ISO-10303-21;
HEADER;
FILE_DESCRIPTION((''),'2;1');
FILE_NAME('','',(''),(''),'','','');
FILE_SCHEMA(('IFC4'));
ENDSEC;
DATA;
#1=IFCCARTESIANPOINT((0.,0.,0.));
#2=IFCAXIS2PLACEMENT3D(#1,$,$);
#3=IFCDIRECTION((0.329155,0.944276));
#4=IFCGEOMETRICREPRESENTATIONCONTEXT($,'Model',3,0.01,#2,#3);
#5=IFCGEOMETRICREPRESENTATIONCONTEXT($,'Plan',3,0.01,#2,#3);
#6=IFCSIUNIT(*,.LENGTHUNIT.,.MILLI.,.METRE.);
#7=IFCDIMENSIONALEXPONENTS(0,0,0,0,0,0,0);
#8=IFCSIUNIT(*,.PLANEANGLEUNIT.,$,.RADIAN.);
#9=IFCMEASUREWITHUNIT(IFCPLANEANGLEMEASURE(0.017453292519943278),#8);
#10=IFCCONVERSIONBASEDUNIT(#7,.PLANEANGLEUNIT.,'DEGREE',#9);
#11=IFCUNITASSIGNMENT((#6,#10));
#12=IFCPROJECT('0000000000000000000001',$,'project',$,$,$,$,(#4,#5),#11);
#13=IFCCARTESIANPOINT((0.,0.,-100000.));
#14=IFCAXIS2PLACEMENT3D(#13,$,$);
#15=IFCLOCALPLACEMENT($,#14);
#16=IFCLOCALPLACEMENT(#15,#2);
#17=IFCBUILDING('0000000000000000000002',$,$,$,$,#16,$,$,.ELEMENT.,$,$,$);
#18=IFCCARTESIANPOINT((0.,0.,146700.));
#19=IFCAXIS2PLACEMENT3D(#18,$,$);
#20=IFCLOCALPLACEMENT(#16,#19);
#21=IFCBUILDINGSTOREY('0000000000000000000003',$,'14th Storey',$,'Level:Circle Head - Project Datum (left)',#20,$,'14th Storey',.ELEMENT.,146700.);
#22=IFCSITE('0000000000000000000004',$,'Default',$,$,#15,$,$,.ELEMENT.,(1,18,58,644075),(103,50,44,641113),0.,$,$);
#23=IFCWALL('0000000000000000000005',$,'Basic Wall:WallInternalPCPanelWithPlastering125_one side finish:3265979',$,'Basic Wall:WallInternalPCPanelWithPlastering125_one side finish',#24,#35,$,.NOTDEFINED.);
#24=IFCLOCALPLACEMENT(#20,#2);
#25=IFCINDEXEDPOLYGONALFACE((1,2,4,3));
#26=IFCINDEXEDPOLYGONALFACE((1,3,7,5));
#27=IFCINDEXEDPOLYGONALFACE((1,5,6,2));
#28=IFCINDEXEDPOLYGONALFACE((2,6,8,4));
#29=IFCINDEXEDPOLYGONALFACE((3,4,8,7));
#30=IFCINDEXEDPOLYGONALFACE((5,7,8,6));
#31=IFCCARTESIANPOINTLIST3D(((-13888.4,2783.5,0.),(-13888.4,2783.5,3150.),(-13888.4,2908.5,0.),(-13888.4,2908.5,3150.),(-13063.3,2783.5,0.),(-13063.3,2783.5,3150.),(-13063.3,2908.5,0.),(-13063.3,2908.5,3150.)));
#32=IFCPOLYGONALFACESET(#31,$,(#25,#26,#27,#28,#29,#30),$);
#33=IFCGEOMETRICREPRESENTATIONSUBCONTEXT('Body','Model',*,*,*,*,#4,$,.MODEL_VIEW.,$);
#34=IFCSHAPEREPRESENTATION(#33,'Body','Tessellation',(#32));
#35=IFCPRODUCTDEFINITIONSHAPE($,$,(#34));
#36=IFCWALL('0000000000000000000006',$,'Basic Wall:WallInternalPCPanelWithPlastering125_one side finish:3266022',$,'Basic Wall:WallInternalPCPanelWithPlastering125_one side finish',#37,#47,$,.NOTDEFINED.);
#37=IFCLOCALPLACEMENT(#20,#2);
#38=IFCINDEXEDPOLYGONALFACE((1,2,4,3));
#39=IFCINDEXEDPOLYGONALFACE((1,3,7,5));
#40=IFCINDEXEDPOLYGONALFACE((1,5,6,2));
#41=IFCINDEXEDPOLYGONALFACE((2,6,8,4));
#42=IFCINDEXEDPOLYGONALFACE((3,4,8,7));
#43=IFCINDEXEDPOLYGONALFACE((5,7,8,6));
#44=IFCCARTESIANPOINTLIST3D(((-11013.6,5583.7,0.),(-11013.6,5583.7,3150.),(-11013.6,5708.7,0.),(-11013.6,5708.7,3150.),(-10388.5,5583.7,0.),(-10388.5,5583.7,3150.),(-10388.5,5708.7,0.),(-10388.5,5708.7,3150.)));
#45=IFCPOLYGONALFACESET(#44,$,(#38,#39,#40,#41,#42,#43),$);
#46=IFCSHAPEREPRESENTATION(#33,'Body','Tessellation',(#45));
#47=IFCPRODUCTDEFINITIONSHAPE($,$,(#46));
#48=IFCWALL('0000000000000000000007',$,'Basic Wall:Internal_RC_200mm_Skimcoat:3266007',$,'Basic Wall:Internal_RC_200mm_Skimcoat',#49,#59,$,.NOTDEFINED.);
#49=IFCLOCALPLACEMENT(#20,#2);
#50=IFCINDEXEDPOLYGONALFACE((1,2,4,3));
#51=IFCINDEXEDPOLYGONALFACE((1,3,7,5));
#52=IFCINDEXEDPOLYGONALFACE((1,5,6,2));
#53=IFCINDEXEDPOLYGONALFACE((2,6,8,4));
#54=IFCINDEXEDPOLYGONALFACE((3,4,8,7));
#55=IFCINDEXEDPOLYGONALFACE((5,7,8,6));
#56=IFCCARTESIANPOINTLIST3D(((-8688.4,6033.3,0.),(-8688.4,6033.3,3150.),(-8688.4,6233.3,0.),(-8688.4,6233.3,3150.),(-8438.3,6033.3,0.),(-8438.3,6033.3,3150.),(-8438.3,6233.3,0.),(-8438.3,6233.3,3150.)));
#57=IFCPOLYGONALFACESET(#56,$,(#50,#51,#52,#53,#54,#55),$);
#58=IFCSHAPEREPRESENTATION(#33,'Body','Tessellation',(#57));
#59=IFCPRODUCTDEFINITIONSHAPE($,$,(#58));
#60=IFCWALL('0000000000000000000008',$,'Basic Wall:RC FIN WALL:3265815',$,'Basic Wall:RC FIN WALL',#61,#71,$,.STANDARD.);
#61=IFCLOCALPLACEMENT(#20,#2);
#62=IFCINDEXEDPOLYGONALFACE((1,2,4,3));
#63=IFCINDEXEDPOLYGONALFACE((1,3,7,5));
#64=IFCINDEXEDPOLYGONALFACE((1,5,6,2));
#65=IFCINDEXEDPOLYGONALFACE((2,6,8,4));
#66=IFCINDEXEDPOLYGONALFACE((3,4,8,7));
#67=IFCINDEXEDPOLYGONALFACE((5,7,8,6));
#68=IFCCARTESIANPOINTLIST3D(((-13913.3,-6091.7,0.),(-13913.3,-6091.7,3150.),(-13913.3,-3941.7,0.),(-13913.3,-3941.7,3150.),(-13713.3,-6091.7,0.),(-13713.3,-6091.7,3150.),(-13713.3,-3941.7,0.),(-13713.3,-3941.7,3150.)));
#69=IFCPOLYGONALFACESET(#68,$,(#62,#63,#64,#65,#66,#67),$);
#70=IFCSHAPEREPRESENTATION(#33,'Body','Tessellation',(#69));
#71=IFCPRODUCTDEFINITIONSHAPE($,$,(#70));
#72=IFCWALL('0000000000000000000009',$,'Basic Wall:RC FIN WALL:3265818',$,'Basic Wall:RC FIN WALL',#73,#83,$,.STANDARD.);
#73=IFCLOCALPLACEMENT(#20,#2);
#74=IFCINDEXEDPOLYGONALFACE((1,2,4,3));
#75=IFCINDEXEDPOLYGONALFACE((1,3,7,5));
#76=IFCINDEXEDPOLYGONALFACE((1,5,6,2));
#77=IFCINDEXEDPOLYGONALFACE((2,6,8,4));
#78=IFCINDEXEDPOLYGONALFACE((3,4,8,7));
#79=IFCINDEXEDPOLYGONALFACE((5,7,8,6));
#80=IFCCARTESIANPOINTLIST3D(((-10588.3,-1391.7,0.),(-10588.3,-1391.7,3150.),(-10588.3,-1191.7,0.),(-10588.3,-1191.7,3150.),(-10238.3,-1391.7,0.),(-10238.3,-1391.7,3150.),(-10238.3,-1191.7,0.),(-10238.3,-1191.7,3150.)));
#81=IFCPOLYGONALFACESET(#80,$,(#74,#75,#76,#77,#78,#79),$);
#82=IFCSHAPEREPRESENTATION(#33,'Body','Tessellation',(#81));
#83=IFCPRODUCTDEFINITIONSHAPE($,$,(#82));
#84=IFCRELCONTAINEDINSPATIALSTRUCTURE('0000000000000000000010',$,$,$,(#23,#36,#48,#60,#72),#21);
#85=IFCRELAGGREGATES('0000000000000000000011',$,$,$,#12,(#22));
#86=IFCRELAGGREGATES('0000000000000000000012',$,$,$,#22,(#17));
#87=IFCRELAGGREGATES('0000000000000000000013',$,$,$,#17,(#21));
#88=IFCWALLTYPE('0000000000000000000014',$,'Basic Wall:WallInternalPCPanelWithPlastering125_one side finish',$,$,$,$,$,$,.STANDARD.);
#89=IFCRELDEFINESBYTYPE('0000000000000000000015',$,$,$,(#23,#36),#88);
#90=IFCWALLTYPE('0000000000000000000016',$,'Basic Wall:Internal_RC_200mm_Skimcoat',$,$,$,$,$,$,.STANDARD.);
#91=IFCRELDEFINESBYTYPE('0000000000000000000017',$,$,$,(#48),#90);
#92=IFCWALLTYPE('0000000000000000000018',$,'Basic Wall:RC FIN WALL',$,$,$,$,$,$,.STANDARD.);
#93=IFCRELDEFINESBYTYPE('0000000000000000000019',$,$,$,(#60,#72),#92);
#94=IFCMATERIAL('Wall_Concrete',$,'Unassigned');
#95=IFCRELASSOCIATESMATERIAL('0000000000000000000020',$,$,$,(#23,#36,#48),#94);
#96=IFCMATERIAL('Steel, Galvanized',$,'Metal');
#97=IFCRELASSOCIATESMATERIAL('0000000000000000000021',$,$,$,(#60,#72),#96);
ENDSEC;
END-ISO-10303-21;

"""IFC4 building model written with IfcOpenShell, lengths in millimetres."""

from ifc_helpers import new_model, entity, si_unit, converted_unit, direction, frame, origin, place, context, subcontext, project, spatial, indexed_curve, outline, extrude, material, type_object, element, save


model = new_model("IFC4")

# Units and contexts
model_context = context("Model", 3, precision=0.01, world=origin(), true_north=direction((0.329155, 0.944276)))
plan_context = context("Plan", 3, precision=0.01, world=origin(), true_north=direction((0.329155, 0.944276)))
body_context = subcontext(model_context, "Body", "Model", "MODEL_VIEW")
ifc_project = project(units=[si_unit("LENGTHUNIT", "METRE", prefix="MILLI"), converted_unit("PLANEANGLEUNIT", "DEGREE", entity("IfcPlaneAngleMeasure", 0.017453292519943278), si_unit("PLANEANGLEUNIT", "RADIAN"), dimensions=[0, 0, 0, 0, 0, 0, 0])], contexts=[model_context, plan_context])

# Site, building, storey
site_placement = place(None, frame((0.0, 0.0, -100000.0)))
site = spatial("IfcSite", under=ifc_project, at=site_placement, Name="Default", CompositionType="ELEMENT", RefLatitude=(1, 18, 58, 644075), RefLongitude=(103, 50, 44, 641113), RefElevation=0.0)
building_placement = place(site_placement, origin())
building = spatial("IfcBuilding", under=site, at=building_placement, CompositionType="ELEMENT")
storey_placement = place(building_placement, frame((0.0, 0.0, 146700.0)))
storey = spatial("IfcBuildingStorey", under=building, at=storey_placement, Name="14th Storey", ObjectType="Level:Circle Head - Project Datum (left)", LongName="14th Storey", CompositionType="ELEMENT", Elevation=146700.0)

# Walls
ifc_material_1 = material(Name="Wall_Concrete", Category="Unassigned")
wall_type_1 = type_object("IfcWallType", Name="Basic Wall:WallInternalPCPanelWithPlastering125_one side finish", PredefinedType="STANDARD")
wall_1_placement = place(storey_placement, frame((-13063.3, 2846.0, 0.0), z_axis=(0.0, 0.0, 1.0), x_axis=(-1.0, 0.0, 0.0)))
element("IfcWall", 1, at=wall_1_placement, inside=storey, type_object=wall_type_1, material=ifc_material_1, Name="Basic Wall:WallInternalPCPanelWithPlastering125_one side finish:3265979", ObjectType="Basic Wall:WallInternalPCPanelWithPlastering125_one side finish", PredefinedType="NOTDEFINED", context=body_context, shape_type="SweptSolid", body=[
    extrude(outline(indexed_curve([(825.1, 62.5), (0.0, 62.5), (0.0, -62.5), (825.1, -62.5), (825.1, 62.5)], self_intersect=False)), origin(), (0.0, 0.0, 1.0), 3150.0),
])
wall_2_placement = place(storey_placement, frame((-11013.6, 5646.2, 0.0)))
element("IfcWall", 2, at=wall_2_placement, inside=storey, type_object=wall_type_1, material=ifc_material_1, Name="Basic Wall:WallInternalPCPanelWithPlastering125_one side finish:3266022", ObjectType="Basic Wall:WallInternalPCPanelWithPlastering125_one side finish", PredefinedType="NOTDEFINED", context=body_context, shape_type="SweptSolid", body=[
    extrude(outline(indexed_curve([(625.1, 62.5), (0.0, 62.5), (0.0, -62.5), (625.1, -62.5), (625.1, 62.5)], self_intersect=False)), origin(), (0.0, 0.0, 1.0), 3150.0),
])
wall_type_2 = type_object("IfcWallType", Name="Basic Wall:Internal_RC_200mm_Skimcoat", PredefinedType="STANDARD")
wall_3_placement = place(storey_placement, frame((-8438.3, 6133.3, 0.0), z_axis=(0.0, 0.0, 1.0), x_axis=(-1.0, 0.0, 0.0)))
element("IfcWall", 3, at=wall_3_placement, inside=storey, type_object=wall_type_2, material=ifc_material_1, Name="Basic Wall:Internal_RC_200mm_Skimcoat:3266007", ObjectType="Basic Wall:Internal_RC_200mm_Skimcoat", PredefinedType="NOTDEFINED", context=body_context, shape_type="SweptSolid", body=[
    extrude(outline(indexed_curve([(250.0, 100.0), (0.0, 100.0), (0.0, -100.0), (250.0, -100.0), (250.0, 100.0)], self_intersect=False)), origin(), (0.0, 0.0, 1.0), 3150.0),
])
ifc_material_2 = material(Name="Steel, Galvanized", Category="Metal")
wall_type_3 = type_object("IfcWallType", Name="Basic Wall:RC FIN WALL", PredefinedType="STANDARD")
wall_4_placement = place(storey_placement, frame((-13813.3, -3941.7, 0.0), z_axis=(0.0, 0.0, 1.0), x_axis=(0.0, -1.0, 0.0)))
element("IfcWall", 4, at=wall_4_placement, inside=storey, type_object=wall_type_3, material=ifc_material_2, Name="Basic Wall:RC FIN WALL:3265815", ObjectType="Basic Wall:RC FIN WALL", PredefinedType="STANDARD", context=body_context, shape_type="SweptSolid", body=[
    extrude(outline(indexed_curve([(2150.0, 100.0), (0.0, 100.0), (0.0, -100.0), (2150.0, -100.0), (2150.0, 100.0)], self_intersect=False)), origin(), (0.0, 0.0, 1.0), 3150.0),
])
wall_5_placement = place(storey_placement, frame((-10238.3, -1291.7, 0.0), z_axis=(0.0, 0.0, 1.0), x_axis=(-1.0, 0.0, 0.0)))
element("IfcWall", 5, at=wall_5_placement, inside=storey, type_object=wall_type_3, material=ifc_material_2, Name="Basic Wall:RC FIN WALL:3265818", ObjectType="Basic Wall:RC FIN WALL", PredefinedType="STANDARD", context=body_context, shape_type="SweptSolid", body=[
    extrude(outline(indexed_curve([(350.0, 100.0), (0.0, 100.0), (0.0, -100.0), (350.0, -100.0), (350.0, 100.0)], self_intersect=False)), origin(), (0.0, 0.0, 1.0), 3150.0),
])

save(model, "model.ifc")
